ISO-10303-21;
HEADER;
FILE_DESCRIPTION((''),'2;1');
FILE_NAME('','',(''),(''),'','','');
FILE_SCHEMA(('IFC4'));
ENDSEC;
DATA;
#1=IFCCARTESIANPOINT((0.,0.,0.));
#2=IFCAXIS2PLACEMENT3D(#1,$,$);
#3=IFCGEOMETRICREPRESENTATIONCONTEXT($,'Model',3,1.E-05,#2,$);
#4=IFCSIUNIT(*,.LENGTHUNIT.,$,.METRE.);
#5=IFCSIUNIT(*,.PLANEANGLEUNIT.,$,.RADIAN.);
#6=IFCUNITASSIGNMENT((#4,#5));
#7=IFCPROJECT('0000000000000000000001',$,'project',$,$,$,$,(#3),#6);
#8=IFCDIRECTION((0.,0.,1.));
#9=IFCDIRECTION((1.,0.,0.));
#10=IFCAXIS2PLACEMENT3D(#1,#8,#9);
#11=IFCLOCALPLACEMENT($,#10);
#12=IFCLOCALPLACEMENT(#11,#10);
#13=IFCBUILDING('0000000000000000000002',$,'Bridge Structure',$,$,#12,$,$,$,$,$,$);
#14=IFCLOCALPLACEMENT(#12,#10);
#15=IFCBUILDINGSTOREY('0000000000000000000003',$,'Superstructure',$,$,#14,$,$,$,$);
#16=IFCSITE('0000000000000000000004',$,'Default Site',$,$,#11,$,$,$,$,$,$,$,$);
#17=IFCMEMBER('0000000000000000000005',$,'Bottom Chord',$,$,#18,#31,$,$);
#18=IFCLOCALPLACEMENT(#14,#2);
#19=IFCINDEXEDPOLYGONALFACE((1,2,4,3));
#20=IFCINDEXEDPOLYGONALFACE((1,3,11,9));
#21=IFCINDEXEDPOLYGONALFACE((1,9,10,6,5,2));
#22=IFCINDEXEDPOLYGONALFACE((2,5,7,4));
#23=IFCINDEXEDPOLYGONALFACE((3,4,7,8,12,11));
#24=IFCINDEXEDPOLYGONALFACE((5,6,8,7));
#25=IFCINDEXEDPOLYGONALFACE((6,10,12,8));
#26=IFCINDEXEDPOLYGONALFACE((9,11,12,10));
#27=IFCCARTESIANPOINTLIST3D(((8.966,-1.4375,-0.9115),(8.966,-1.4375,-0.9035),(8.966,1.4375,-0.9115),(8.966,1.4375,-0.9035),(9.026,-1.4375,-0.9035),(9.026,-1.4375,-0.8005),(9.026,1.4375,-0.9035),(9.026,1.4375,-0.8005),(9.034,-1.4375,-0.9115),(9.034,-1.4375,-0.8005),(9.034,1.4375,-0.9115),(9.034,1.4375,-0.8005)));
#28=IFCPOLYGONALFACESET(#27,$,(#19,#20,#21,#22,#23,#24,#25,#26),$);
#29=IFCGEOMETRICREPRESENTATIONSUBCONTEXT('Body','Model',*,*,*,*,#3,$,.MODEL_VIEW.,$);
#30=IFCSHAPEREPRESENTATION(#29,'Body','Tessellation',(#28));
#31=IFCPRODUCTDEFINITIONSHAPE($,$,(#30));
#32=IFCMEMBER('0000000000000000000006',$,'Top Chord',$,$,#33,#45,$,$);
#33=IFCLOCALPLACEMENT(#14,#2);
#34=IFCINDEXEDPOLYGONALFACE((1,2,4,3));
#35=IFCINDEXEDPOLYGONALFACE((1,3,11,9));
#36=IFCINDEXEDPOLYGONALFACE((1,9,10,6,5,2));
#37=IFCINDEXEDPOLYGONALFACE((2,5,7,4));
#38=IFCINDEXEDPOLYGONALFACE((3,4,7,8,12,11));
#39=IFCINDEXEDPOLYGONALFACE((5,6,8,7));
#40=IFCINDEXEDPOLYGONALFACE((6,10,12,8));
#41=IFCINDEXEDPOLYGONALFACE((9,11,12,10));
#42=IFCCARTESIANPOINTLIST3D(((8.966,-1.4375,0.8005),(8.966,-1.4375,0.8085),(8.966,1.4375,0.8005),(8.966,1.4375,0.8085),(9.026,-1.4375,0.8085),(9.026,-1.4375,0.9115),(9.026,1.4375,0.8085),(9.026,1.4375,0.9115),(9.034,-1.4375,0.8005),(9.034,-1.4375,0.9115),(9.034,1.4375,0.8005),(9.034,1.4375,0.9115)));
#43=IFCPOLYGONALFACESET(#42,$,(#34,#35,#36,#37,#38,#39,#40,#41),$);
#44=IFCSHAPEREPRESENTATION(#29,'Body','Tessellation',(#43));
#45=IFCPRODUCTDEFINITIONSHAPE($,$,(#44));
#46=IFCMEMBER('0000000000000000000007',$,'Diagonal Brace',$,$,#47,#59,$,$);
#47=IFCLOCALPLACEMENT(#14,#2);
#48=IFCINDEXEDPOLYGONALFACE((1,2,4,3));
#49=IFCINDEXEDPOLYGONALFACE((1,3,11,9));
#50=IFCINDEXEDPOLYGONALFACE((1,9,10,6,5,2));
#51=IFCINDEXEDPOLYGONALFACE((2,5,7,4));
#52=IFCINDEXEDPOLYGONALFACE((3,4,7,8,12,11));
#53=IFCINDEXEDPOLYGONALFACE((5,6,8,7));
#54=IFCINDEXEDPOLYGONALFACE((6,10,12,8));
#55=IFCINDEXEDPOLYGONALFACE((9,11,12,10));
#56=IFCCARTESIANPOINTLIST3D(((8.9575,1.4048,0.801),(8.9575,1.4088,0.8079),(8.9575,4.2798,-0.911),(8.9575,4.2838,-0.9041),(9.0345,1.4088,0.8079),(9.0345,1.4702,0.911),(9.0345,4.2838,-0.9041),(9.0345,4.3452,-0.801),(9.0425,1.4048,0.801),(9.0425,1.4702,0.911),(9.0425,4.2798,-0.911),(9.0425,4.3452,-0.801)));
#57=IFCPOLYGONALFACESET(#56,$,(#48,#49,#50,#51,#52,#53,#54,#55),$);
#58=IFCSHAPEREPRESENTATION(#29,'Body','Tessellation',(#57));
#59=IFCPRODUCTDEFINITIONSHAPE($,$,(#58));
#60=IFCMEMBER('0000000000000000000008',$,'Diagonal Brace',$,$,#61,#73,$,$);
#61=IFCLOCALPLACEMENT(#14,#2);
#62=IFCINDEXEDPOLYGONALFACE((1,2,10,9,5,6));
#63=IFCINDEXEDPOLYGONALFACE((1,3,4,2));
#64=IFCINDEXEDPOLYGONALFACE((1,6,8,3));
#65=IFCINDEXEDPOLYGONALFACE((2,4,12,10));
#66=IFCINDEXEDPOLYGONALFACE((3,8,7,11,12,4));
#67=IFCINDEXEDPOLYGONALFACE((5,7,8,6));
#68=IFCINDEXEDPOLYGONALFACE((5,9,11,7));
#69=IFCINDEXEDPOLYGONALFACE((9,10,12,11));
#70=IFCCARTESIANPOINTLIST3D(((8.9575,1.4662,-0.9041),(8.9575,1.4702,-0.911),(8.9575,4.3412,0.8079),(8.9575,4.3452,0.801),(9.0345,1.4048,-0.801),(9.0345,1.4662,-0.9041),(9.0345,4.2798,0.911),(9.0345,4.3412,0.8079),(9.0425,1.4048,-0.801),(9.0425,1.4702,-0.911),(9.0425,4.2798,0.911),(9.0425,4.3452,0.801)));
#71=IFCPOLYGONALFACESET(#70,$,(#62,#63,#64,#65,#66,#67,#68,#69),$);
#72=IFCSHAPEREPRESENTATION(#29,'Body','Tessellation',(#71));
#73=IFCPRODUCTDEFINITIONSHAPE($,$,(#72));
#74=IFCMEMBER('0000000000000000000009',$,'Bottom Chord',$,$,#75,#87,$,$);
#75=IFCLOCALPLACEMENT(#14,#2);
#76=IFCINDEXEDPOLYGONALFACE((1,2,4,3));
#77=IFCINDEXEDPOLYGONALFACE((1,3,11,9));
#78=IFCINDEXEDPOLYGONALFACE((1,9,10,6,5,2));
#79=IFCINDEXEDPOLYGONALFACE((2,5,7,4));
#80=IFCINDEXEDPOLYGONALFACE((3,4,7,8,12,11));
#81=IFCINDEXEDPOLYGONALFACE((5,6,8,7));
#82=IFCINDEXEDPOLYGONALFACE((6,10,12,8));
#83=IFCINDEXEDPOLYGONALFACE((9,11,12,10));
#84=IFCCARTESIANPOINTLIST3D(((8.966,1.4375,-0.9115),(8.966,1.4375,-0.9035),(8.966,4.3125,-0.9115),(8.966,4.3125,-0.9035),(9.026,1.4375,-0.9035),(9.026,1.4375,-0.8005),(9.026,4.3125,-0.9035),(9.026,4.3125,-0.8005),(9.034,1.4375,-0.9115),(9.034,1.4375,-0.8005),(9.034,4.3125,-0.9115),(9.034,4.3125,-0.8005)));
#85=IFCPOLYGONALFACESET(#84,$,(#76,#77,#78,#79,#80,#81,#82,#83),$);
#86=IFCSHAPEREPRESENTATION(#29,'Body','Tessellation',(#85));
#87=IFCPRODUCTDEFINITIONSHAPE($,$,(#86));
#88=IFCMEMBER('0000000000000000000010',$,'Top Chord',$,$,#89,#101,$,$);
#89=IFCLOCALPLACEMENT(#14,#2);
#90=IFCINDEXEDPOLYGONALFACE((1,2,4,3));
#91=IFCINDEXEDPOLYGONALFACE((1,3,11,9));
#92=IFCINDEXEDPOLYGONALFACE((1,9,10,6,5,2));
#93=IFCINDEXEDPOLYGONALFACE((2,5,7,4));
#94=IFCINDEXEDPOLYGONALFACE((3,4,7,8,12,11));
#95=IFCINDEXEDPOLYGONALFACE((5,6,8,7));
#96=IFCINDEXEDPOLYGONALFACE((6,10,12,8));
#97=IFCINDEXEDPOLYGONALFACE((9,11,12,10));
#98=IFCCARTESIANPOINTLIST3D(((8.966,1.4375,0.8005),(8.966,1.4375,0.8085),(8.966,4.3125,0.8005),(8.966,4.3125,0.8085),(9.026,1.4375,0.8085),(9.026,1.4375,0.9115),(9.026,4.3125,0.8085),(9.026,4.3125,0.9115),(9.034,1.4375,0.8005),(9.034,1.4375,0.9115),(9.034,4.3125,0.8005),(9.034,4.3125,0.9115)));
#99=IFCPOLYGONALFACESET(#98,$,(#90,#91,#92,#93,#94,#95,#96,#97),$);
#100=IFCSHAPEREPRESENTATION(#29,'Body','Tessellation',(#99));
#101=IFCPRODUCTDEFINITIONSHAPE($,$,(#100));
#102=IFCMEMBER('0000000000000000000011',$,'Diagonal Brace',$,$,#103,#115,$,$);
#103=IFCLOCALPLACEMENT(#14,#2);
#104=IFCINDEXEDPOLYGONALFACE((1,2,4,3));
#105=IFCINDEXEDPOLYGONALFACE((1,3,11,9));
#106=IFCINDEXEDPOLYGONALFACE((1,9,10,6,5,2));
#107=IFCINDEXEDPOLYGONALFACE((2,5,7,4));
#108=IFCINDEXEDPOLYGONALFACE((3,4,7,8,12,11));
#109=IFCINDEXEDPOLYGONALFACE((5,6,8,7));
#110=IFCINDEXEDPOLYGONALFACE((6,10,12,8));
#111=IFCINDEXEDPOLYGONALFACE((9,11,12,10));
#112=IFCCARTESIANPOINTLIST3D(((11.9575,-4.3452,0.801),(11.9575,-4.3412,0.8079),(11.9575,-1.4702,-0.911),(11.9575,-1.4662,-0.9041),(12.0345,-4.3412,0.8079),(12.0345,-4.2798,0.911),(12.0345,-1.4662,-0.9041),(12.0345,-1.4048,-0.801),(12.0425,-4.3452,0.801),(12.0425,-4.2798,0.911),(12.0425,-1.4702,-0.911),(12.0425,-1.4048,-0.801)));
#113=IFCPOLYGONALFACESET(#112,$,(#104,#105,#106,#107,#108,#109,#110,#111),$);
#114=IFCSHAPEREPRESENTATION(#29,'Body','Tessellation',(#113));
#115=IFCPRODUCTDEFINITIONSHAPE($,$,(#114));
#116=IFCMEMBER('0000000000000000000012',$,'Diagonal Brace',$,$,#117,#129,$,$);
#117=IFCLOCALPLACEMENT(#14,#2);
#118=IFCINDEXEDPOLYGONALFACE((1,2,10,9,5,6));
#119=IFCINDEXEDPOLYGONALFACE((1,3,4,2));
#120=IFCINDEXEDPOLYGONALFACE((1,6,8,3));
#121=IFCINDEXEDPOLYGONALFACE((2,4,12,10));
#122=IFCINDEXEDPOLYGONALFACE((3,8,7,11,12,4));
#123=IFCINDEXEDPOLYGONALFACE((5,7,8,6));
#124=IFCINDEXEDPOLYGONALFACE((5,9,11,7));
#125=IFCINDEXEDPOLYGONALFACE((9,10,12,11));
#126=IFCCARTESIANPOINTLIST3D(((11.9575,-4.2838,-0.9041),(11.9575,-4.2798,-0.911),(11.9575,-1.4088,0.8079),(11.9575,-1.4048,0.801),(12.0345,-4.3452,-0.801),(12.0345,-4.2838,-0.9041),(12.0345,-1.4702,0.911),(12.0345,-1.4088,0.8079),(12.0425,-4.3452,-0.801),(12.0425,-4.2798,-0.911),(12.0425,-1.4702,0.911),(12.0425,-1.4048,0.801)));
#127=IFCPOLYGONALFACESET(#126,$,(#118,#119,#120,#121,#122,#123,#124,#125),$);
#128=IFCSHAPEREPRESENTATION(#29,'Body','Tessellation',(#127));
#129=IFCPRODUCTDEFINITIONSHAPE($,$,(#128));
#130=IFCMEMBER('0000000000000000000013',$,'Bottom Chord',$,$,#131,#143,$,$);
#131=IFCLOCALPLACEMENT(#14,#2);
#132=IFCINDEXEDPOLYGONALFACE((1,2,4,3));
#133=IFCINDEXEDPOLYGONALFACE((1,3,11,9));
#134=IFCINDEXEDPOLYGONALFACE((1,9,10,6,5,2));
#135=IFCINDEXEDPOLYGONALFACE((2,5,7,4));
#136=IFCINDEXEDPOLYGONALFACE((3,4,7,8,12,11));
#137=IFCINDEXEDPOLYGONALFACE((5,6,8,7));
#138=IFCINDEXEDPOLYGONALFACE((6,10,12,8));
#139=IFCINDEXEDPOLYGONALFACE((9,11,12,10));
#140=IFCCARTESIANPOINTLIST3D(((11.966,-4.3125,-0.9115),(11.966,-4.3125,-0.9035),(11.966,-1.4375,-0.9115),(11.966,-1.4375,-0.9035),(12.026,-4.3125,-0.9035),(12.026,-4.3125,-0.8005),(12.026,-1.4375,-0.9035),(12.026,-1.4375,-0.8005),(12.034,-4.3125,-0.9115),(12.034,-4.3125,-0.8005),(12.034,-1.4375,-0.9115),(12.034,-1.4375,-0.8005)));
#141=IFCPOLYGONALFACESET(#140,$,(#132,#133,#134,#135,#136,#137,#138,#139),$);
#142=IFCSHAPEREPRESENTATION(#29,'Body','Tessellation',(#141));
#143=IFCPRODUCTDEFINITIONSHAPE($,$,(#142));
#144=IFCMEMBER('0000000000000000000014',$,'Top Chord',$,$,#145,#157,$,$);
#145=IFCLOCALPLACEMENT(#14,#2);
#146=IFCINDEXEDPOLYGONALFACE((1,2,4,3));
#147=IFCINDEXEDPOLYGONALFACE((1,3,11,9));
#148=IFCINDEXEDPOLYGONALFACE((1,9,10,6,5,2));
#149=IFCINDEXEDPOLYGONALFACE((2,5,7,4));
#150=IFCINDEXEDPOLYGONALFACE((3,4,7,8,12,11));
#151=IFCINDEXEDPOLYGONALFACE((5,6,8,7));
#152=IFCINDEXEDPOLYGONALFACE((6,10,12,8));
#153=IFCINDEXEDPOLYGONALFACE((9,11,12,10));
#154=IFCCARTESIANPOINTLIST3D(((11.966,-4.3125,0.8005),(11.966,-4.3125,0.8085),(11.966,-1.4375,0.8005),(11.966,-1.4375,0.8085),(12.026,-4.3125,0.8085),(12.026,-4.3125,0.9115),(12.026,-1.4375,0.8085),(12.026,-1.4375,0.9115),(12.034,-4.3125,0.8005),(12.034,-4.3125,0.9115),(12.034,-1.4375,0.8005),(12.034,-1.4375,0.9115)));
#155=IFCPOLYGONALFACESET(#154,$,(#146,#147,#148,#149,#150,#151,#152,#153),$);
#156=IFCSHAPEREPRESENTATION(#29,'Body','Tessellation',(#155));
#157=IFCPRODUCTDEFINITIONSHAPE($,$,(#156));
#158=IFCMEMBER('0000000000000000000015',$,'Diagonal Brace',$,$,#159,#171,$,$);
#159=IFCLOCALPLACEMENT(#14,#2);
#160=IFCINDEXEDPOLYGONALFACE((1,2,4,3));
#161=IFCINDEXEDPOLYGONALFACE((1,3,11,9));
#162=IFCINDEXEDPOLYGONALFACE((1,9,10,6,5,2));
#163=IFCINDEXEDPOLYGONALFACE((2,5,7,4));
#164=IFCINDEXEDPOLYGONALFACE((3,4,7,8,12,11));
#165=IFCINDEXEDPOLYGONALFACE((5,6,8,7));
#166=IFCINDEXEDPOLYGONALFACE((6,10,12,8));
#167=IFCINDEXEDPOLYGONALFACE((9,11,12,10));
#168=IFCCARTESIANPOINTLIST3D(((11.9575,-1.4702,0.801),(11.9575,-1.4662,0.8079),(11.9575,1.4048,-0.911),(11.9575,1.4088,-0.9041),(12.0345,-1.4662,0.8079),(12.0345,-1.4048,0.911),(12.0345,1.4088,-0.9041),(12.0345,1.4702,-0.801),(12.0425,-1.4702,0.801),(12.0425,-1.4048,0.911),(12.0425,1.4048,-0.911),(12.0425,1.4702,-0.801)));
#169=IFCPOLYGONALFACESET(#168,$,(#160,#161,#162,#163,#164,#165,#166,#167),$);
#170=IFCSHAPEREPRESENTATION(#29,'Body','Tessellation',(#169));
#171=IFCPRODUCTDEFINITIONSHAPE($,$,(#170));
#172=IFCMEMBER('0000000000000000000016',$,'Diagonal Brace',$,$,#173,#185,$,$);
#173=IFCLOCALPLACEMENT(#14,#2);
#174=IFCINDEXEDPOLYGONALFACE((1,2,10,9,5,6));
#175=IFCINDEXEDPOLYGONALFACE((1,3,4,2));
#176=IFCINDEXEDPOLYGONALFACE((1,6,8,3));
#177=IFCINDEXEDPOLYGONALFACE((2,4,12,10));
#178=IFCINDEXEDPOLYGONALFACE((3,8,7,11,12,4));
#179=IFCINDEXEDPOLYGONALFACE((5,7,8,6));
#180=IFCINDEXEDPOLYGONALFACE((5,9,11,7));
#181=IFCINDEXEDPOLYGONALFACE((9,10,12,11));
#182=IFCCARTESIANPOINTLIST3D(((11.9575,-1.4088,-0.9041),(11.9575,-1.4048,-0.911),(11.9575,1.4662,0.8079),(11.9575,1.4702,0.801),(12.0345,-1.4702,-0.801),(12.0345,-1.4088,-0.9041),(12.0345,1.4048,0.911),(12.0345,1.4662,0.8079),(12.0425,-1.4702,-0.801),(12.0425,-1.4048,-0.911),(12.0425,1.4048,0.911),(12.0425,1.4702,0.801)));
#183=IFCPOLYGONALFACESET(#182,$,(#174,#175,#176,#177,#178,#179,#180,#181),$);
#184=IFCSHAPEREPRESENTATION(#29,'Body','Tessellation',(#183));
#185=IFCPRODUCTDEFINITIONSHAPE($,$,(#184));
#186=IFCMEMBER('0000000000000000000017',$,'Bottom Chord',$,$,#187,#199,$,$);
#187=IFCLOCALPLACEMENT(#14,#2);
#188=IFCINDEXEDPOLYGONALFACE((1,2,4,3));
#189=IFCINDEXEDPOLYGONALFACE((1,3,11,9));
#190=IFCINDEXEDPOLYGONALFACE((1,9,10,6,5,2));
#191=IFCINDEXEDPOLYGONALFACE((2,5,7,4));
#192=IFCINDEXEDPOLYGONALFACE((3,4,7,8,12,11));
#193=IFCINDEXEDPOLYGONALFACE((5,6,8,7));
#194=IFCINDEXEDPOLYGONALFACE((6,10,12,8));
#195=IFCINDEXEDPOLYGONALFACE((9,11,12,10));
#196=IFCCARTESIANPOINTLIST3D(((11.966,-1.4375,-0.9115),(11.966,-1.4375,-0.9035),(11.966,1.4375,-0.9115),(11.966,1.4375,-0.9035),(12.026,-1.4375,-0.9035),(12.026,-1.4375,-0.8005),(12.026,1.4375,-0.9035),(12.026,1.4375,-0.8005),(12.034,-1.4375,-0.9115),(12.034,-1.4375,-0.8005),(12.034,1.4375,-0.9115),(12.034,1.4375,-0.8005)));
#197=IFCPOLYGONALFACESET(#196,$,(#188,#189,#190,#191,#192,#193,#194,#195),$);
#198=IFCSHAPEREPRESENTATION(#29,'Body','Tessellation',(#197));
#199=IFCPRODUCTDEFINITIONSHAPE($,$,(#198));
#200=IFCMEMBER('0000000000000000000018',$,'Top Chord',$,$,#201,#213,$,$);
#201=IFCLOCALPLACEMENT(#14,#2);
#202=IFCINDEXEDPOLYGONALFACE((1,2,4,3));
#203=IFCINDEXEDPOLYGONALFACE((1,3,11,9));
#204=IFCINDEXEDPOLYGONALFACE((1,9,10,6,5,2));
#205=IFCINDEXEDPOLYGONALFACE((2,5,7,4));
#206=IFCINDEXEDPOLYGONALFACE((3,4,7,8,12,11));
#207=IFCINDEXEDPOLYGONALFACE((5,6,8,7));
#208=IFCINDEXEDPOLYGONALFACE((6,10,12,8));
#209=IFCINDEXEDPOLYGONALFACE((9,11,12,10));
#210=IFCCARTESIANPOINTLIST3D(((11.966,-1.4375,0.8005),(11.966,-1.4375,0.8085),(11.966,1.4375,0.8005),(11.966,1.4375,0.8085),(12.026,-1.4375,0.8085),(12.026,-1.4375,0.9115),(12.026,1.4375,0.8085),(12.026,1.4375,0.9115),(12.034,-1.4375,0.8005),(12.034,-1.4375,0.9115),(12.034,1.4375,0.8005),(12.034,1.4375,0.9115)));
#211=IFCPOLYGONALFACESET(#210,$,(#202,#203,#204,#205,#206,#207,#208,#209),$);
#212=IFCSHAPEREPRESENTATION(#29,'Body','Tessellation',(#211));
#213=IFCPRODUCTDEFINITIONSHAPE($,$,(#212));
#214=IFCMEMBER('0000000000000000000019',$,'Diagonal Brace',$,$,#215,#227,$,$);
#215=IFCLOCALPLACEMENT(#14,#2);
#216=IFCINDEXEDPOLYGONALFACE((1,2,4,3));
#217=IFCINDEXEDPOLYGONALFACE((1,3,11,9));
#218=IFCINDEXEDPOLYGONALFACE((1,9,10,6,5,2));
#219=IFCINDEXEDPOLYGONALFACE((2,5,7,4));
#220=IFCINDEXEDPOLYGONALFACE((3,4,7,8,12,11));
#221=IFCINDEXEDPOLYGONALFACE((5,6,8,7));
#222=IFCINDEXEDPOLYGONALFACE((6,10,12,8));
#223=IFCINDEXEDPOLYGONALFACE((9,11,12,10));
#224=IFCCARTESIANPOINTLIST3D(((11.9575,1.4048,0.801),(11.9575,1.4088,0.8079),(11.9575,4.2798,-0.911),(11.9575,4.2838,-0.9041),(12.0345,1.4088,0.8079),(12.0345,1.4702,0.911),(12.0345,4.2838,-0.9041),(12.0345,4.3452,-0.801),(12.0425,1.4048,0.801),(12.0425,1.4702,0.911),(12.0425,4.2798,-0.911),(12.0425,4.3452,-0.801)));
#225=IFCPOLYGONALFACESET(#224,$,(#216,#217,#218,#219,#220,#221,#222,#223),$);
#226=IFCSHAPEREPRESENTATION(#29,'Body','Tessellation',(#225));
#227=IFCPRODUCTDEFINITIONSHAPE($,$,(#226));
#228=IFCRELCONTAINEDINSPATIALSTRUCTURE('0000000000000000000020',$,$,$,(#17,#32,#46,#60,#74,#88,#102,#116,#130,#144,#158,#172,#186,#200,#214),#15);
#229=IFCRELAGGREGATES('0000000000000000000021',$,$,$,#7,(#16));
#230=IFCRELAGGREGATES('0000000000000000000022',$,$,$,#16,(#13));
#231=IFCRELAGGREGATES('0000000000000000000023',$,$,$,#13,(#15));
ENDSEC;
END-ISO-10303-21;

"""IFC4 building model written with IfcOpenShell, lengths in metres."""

from ifc_helpers import new_model, si_unit, frame, origin, origin_with_axes, origin_2d_with_axis, place, context, subcontext, project, spatial, l_section, extrude, element, save


model = new_model("IFC4")

# Units and contexts
model_context = context("Model", 3, precision=1e-05, world=origin())
body_context = subcontext(model_context, "Body", "Model", "MODEL_VIEW")
ifc_project = project(units=[si_unit("LENGTHUNIT", "METRE"), si_unit("PLANEANGLEUNIT", "RADIAN")], contexts=[model_context])

# Site, building, storey
site_placement = place(None, origin_with_axes())
site = spatial("IfcSite", under=ifc_project, at=site_placement, Name="Default Site")
building_placement = place(site_placement, origin_with_axes())
building = spatial("IfcBuilding", under=site, at=building_placement, Name="Bridge Structure")
storey_placement = place(building_placement, origin_with_axes())
storey = spatial("IfcBuildingStorey", under=building, at=storey_placement, Name="Superstructure")

# Members
for number, where, z_axis, x_axis, name in (
    (1, (9.0, -1.4375, -0.856), (0.0, 1.0, 0.0), (-1.0, 0.0, 0.0), "Bottom Chord"),
    (2, (9.0, -1.4375, 0.856), (0.0, 1.0, 0.0), (-1.0, 0.0, 0.0), "Top Chord"),
):
    element("IfcMember", number, at=place(storey_placement, frame(where, z_axis=z_axis, x_axis=x_axis)), inside=storey, Name=name, context=body_context, shape_type="SweptSolid", body=[
        extrude(l_section(Depth=0.111, Width=0.068, Thickness=0.008, at=origin_2d_with_axis()), origin_with_axes(), (0.0, 0.0, 1.0), 2.875),
    ])
for number, where, z_axis, x_axis, name in (
    (3, (9.0, 1.4375, 0.856), (0.0, 0.859202, -0.511636), (-1.0, 0.0, 0.0), "Diagonal Brace"),
    (4, (9.0, 1.4375, -0.856), (0.0, 0.859202, 0.511636), (-1.0, 0.0, 0.0), "Diagonal Brace"),
):
    element("IfcMember", number, at=place(storey_placement, frame(where, z_axis=z_axis, x_axis=x_axis)), inside=storey, Name=name, context=body_context, shape_type="SweptSolid", body=[
        extrude(l_section(Depth=0.128, Width=0.085, Thickness=0.008, at=origin_2d_with_axis()), origin_with_axes(), (0.0, 0.0, 1.0), 3.3461),
    ])
for number, where, z_axis, x_axis, name in (
    (5, (9.0, 1.4375, -0.856), (0.0, 1.0, 0.0), (-1.0, 0.0, 0.0), "Bottom Chord"),
    (6, (9.0, 1.4375, 0.856), (0.0, 1.0, 0.0), (-1.0, 0.0, 0.0), "Top Chord"),
):
    element("IfcMember", number, at=place(storey_placement, frame(where, z_axis=z_axis, x_axis=x_axis)), inside=storey, Name=name, context=body_context, shape_type="SweptSolid", body=[
        extrude(l_section(Depth=0.111, Width=0.068, Thickness=0.008, at=origin_2d_with_axis()), origin_with_axes(), (0.0, 0.0, 1.0), 2.875),
    ])
for number, where, z_axis, x_axis, name in (
    (7, (12.0, -4.3125, 0.856), (0.0, 0.859202, -0.511636), (-1.0, 0.0, 0.0), "Diagonal Brace"),
    (8, (12.0, -4.3125, -0.856), (0.0, 0.859202, 0.511636), (-1.0, 0.0, 0.0), "Diagonal Brace"),
):
    element("IfcMember", number, at=place(storey_placement, frame(where, z_axis=z_axis, x_axis=x_axis)), inside=storey, Name=name, context=body_context, shape_type="SweptSolid", body=[
        extrude(l_section(Depth=0.128, Width=0.085, Thickness=0.008, at=origin_2d_with_axis()), origin_with_axes(), (0.0, 0.0, 1.0), 3.3461),
    ])
for number, where, z_axis, x_axis, name in (
    (9, (12.0, -4.3125, -0.856), (0.0, 1.0, 0.0), (-1.0, 0.0, 0.0), "Bottom Chord"),
    (10, (12.0, -4.3125, 0.856), (0.0, 1.0, 0.0), (-1.0, 0.0, 0.0), "Top Chord"),
):
    element("IfcMember", number, at=place(storey_placement, frame(where, z_axis=z_axis, x_axis=x_axis)), inside=storey, Name=name, context=body_context, shape_type="SweptSolid", body=[
        extrude(l_section(Depth=0.111, Width=0.068, Thickness=0.008, at=origin_2d_with_axis()), origin_with_axes(), (0.0, 0.0, 1.0), 2.875),
    ])
for number, where, z_axis, x_axis, name in (
    (11, (12.0, -1.4375, 0.856), (0.0, 0.859202, -0.511636), (-1.0, 0.0, 0.0), "Diagonal Brace"),
    (12, (12.0, -1.4375, -0.856), (0.0, 0.859202, 0.511636), (-1.0, 0.0, 0.0), "Diagonal Brace"),
):
    element("IfcMember", number, at=place(storey_placement, frame(where, z_axis=z_axis, x_axis=x_axis)), inside=storey, Name=name, context=body_context, shape_type="SweptSolid", body=[
        extrude(l_section(Depth=0.128, Width=0.085, Thickness=0.008, at=origin_2d_with_axis()), origin_with_axes(), (0.0, 0.0, 1.0), 3.3461),
    ])
for number, where, z_axis, x_axis, name in (
    (13, (12.0, -1.4375, -0.856), (0.0, 1.0, 0.0), (-1.0, 0.0, 0.0), "Bottom Chord"),
    (14, (12.0, -1.4375, 0.856), (0.0, 1.0, 0.0), (-1.0, 0.0, 0.0), "Top Chord"),
):
    element("IfcMember", number, at=place(storey_placement, frame(where, z_axis=z_axis, x_axis=x_axis)), inside=storey, Name=name, context=body_context, shape_type="SweptSolid", body=[
        extrude(l_section(Depth=0.111, Width=0.068, Thickness=0.008, at=origin_2d_with_axis()), origin_with_axes(), (0.0, 0.0, 1.0), 2.875),
    ])
for number, where, z_axis, x_axis, name in (
    (15, (12.0, 1.4375, 0.856), (0.0, 0.859202, -0.511636), (-1.0, 0.0, 0.0), "Diagonal Brace"),
):
    element("IfcMember", number, at=place(storey_placement, frame(where, z_axis=z_axis, x_axis=x_axis)), inside=storey, Name=name, context=body_context, shape_type="SweptSolid", body=[
        extrude(l_section(Depth=0.128, Width=0.085, Thickness=0.008, at=origin_2d_with_axis()), origin_with_axes(), (0.0, 0.0, 1.0), 3.3461),
    ])

save(model, "model.ifc")
